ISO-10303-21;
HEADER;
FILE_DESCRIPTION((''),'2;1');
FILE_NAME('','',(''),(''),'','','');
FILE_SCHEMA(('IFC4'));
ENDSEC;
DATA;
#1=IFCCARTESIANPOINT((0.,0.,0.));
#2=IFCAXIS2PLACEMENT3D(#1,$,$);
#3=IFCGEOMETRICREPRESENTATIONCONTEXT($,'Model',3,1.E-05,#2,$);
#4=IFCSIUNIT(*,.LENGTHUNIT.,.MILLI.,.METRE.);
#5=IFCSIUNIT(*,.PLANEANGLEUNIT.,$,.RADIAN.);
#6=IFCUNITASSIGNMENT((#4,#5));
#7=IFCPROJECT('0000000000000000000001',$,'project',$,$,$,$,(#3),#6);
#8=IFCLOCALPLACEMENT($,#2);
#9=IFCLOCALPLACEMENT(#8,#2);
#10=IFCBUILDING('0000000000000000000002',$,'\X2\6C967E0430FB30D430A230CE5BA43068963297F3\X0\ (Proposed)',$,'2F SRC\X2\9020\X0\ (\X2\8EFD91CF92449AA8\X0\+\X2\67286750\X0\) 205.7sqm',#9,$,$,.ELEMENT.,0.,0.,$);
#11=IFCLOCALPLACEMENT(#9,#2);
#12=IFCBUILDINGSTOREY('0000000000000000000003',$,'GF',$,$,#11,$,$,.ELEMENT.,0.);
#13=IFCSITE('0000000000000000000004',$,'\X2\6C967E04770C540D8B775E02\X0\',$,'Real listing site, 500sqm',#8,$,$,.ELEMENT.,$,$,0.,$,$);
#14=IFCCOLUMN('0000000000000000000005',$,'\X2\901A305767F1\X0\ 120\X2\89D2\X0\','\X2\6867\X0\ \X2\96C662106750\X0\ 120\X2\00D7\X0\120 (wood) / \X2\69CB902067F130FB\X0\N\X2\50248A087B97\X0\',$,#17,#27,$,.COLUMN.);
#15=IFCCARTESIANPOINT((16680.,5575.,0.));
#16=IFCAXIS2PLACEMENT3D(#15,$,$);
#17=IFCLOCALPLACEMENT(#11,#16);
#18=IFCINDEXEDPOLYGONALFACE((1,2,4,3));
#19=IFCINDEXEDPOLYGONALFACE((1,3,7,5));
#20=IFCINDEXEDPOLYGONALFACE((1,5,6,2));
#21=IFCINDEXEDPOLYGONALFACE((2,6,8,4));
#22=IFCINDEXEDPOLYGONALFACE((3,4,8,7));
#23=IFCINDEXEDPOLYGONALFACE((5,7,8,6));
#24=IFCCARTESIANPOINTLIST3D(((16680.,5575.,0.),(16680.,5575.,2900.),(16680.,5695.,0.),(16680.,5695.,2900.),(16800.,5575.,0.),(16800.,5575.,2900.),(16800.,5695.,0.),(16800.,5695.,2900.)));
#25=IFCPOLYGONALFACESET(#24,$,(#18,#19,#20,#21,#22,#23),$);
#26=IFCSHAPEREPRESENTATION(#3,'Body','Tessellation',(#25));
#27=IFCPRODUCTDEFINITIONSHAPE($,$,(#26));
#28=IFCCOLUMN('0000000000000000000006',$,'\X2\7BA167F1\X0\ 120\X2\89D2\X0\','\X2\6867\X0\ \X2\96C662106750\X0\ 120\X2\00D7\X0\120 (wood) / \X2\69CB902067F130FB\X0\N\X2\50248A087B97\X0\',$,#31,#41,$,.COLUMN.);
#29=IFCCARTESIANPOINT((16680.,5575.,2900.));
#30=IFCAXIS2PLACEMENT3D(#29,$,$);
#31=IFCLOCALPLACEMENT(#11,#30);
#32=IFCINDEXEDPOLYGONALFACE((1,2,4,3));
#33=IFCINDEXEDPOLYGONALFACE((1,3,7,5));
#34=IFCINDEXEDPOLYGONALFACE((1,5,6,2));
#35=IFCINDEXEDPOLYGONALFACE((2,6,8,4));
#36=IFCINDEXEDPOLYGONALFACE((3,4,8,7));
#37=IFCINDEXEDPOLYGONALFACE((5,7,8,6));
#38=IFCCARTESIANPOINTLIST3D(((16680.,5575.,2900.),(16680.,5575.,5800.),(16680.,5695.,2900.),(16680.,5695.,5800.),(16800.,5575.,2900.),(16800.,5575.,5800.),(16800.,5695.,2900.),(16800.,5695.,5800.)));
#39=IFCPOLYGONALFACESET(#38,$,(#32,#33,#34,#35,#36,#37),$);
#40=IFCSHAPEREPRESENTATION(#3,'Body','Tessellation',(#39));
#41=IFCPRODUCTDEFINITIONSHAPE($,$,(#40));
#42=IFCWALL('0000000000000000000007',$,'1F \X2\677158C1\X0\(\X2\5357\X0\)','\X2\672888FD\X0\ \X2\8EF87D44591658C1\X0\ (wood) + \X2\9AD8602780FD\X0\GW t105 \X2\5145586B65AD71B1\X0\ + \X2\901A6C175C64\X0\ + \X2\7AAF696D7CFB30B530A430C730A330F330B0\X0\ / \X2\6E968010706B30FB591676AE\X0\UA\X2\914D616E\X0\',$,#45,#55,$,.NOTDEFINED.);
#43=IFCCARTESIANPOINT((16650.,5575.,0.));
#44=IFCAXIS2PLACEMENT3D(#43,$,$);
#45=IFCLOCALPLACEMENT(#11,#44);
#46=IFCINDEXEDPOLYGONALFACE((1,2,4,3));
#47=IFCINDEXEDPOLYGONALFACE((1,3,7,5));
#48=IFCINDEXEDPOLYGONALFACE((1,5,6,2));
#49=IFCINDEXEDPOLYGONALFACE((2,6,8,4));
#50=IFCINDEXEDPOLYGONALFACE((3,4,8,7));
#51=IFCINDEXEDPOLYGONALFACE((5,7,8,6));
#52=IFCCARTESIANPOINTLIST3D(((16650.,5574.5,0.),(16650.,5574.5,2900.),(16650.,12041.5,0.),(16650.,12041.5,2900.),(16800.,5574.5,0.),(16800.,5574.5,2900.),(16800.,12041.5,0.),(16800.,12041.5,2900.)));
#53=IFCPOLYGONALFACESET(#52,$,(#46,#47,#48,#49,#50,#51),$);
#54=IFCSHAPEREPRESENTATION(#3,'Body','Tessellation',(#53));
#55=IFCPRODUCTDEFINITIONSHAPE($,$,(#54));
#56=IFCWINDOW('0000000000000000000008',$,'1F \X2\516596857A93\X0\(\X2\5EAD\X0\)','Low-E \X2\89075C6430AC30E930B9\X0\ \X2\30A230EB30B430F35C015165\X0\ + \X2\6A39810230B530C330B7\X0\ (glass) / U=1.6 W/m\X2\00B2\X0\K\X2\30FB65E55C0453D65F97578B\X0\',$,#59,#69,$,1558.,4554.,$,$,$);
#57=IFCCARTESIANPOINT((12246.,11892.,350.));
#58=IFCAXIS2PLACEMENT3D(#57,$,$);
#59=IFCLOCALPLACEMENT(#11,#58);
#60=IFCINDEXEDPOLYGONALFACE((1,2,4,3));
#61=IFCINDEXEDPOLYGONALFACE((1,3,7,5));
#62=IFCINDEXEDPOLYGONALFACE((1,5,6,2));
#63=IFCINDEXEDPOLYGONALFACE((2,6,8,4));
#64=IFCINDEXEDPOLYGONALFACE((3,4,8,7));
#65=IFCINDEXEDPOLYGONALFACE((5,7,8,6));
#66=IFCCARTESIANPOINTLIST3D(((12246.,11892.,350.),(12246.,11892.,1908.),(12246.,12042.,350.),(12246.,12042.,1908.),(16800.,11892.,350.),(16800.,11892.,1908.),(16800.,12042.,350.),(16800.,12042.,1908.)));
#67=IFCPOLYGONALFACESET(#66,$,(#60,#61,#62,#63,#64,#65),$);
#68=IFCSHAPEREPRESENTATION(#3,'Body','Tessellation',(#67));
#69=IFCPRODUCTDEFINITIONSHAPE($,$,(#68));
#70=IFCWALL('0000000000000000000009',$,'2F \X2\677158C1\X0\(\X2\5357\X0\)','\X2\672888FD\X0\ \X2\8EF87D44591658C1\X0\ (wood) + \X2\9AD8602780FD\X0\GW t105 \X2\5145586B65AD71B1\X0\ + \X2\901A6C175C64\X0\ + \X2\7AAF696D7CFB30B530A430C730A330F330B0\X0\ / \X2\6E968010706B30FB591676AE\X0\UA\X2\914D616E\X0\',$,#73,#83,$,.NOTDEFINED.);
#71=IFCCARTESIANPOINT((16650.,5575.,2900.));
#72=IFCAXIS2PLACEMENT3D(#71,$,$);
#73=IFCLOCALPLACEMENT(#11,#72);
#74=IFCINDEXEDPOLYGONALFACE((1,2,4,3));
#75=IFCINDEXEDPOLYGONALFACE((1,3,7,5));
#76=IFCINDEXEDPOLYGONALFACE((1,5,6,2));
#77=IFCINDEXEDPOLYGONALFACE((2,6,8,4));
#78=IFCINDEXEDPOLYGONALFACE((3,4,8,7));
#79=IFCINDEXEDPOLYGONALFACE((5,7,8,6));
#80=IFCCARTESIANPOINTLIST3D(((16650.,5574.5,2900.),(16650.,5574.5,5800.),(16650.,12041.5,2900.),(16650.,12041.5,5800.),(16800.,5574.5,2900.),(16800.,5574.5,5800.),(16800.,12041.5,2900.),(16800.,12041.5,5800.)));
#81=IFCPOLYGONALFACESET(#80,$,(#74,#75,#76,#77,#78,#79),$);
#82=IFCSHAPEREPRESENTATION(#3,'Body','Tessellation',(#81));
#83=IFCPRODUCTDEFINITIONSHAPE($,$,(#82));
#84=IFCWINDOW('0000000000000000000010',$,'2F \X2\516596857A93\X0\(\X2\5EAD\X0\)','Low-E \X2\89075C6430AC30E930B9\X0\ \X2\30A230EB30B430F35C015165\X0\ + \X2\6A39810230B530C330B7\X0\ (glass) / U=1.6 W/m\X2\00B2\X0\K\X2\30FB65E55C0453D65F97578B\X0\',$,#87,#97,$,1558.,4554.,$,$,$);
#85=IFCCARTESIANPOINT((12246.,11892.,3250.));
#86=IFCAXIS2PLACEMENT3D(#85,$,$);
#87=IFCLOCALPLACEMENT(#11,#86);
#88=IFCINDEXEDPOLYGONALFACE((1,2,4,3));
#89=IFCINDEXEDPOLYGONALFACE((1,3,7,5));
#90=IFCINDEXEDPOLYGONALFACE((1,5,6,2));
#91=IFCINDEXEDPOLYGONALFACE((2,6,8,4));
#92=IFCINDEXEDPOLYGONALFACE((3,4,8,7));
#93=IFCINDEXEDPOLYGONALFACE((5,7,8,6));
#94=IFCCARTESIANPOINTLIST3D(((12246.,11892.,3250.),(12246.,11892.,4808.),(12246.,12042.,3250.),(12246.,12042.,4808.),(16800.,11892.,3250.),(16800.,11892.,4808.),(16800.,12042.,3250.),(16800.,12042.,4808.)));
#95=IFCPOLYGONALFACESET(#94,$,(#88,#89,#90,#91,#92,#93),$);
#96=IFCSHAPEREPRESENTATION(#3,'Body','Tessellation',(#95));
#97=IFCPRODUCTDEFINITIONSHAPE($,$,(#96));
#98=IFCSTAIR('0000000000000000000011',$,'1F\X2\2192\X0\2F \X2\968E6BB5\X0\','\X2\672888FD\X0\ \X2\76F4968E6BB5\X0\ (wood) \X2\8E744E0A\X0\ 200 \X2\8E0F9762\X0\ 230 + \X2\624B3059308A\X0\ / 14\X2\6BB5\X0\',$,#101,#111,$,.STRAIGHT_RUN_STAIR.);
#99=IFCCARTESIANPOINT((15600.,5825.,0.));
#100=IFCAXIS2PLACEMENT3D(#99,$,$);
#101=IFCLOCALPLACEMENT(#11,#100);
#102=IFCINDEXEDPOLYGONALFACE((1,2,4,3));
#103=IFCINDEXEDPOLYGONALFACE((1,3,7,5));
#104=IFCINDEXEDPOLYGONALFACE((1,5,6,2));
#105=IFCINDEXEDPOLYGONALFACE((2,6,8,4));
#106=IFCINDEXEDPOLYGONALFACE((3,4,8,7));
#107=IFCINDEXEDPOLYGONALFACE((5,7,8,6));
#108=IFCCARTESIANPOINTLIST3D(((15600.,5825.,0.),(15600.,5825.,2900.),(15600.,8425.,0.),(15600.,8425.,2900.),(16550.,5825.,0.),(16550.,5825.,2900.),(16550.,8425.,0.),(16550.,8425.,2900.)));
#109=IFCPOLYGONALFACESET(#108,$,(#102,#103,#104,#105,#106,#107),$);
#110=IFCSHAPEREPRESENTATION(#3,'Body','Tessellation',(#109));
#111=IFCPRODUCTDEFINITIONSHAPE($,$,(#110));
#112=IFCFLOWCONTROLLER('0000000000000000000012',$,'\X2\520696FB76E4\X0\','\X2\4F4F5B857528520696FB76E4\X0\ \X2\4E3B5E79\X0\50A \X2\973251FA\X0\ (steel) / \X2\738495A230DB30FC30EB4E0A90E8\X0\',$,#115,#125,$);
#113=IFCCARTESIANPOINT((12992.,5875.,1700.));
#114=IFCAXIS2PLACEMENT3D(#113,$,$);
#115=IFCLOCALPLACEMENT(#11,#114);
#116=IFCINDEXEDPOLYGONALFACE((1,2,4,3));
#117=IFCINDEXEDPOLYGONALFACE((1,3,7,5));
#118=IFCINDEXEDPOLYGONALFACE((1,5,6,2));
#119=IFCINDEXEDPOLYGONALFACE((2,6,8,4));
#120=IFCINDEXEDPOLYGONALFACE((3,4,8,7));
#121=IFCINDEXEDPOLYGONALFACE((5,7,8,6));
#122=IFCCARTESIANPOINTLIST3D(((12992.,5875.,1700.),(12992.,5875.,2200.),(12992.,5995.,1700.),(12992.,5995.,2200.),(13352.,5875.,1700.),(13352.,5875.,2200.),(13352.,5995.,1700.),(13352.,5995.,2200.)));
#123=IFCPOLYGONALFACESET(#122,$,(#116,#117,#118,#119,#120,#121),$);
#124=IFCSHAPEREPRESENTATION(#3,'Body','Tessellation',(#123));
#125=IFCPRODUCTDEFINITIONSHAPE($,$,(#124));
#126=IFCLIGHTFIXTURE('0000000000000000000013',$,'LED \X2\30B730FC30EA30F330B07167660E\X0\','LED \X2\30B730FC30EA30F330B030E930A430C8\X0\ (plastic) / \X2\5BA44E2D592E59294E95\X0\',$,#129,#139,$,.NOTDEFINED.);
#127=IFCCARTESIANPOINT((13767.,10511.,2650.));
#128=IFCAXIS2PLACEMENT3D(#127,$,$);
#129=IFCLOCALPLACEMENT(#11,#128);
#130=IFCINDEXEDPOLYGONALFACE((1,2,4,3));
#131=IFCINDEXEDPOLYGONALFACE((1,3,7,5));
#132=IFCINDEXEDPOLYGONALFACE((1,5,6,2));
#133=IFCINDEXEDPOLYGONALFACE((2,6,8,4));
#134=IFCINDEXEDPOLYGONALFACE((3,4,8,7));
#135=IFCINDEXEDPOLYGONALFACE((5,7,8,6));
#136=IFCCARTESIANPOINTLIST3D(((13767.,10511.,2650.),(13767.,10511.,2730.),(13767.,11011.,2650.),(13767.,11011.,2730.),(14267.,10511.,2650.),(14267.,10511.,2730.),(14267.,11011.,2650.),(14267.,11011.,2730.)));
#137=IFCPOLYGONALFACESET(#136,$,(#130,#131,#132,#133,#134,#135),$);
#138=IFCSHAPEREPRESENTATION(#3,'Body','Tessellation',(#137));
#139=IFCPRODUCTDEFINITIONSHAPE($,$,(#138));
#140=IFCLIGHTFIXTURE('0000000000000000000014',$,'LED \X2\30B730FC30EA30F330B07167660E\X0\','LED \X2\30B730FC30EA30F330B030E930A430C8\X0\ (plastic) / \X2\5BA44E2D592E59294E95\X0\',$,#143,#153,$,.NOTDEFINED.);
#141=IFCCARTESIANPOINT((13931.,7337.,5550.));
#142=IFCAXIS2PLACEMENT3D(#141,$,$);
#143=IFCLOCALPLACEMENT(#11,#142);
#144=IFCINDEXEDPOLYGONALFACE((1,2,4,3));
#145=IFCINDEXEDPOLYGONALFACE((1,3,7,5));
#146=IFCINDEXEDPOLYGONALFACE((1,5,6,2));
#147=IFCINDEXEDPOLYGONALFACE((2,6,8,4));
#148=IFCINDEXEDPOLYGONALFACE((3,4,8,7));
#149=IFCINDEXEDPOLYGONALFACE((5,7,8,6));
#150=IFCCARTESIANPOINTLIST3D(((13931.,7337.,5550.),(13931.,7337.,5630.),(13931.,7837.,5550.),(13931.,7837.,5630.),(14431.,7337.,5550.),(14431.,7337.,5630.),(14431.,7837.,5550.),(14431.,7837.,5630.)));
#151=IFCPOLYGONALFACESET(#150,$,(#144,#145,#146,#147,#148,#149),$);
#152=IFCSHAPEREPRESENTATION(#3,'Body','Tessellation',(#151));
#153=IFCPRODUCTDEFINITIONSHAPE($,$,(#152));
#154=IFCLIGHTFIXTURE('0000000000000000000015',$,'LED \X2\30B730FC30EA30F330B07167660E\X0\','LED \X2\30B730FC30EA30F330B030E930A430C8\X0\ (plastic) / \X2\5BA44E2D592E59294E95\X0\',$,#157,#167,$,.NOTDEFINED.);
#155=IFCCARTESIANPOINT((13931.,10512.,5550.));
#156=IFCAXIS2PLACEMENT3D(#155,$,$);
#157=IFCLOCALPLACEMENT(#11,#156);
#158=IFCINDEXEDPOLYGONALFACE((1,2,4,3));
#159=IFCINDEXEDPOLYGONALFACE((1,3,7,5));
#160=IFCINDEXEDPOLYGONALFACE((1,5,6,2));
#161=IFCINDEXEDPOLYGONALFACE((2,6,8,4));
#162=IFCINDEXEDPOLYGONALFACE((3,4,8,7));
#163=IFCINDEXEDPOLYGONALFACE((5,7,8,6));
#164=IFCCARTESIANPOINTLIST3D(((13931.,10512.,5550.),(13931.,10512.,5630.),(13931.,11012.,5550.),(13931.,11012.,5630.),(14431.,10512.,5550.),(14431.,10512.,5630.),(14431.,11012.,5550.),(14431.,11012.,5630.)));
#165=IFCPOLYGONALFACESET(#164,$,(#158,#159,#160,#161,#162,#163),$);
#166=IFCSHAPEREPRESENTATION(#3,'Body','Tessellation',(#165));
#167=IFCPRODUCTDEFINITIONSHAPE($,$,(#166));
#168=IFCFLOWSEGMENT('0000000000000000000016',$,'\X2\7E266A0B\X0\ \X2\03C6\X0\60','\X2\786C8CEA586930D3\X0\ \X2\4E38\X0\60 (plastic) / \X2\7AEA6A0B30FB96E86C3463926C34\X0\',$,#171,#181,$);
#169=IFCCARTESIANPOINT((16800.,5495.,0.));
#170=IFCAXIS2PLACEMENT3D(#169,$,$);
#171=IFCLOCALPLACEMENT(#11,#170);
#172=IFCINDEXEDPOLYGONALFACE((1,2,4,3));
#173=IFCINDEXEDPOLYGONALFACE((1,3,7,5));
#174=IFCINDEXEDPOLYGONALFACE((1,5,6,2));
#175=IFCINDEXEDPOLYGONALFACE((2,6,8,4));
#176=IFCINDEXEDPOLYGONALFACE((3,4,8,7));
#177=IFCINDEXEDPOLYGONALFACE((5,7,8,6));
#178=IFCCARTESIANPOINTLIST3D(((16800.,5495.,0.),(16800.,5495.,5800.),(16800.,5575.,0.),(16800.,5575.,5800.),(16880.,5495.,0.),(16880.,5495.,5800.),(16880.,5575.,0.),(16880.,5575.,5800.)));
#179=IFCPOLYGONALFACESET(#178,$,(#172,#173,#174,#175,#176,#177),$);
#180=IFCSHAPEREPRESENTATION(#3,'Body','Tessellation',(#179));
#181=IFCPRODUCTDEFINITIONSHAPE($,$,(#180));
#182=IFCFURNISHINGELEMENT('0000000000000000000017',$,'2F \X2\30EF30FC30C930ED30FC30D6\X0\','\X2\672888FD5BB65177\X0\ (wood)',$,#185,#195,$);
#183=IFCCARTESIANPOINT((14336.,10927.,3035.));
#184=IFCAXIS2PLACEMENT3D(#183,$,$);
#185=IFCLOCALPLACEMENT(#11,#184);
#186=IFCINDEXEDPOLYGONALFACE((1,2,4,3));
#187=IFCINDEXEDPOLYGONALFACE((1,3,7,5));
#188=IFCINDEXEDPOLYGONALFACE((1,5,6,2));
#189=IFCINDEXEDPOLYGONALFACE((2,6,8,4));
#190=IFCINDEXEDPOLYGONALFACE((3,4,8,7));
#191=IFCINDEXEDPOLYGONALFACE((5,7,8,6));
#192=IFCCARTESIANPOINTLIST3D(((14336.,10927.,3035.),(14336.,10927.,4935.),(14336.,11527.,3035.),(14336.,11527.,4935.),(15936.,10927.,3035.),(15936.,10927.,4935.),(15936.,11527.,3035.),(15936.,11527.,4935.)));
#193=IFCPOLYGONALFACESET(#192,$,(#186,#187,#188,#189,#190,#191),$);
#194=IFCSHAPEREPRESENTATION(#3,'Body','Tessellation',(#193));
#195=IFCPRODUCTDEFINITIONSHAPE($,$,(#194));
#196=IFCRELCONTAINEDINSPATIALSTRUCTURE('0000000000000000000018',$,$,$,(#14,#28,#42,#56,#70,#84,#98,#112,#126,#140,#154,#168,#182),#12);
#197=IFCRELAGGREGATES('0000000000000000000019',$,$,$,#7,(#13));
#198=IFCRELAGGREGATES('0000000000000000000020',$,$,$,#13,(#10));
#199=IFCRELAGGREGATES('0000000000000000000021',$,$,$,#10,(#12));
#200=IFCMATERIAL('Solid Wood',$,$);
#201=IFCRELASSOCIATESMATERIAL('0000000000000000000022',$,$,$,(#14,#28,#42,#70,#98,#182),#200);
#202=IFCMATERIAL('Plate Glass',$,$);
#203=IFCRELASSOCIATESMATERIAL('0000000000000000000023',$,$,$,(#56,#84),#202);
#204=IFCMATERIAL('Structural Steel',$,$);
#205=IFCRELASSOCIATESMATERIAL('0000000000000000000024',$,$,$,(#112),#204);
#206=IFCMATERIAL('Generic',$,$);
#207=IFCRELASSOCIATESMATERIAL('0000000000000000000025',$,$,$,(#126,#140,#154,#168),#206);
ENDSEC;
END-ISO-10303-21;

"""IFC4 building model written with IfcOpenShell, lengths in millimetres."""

from ifc_helpers import new_model, si_unit, frame, frame_2d, origin, place, context, project, spatial, rectangle, extrude, material, element, fill, save


model = new_model("IFC4")

# Units and contexts
model_context = context("Model", 3, precision=1e-05, world=origin())
ifc_project = project(units=[si_unit("LENGTHUNIT", "METRE", prefix="MILLI"), si_unit("PLANEANGLEUNIT", "RADIAN")], contexts=[model_context])

# Site, building, storey
site_placement = place(None, origin())
site = spatial("IfcSite", under=ifc_project, at=site_placement, Name="沖縄県名護市", ObjectType="Real listing site, 500sqm", CompositionType="ELEMENT", RefElevation=0.0)
building_placement = place(site_placement, origin())
building = spatial("IfcBuilding", under=site, at=building_placement, Name="沖縄・ピアノ室と防音 (Proposed)", ObjectType="2F SRC造 (軽量鉄骨+木材) 205.7sqm", CompositionType="ELEMENT", ElevationOfRefHeight=0.0, ElevationOfTerrain=0.0)
storey_placement = place(building_placement, origin())
storey = spatial("IfcBuildingStorey", under=building, at=storey_placement, Name="GF", CompositionType="ELEMENT", Elevation=0.0)

# Columns
ifc_material_1 = material(Name="Solid Wood")
column_1_placement = place(storey_placement, frame((16680.0, 5575.0, 0.0)))
element("IfcColumn", 1, at=column_1_placement, inside=storey, material=ifc_material_1, Name="通し柱 120角", Description="桧 集成材 120×120 (wood) / 構造柱・N値計算", PredefinedType="COLUMN", context=model_context, shape_type="SweptSolid", body=[
    extrude(rectangle(XDim=120.0, YDim=120.0, at=frame_2d((60.0, 60.0))), frame((16680.0, 5575.0, 0.0)), (0.0, 0.0, 1.0), 2900.0),
])
column_2_placement = place(storey_placement, frame((16680.0, 5575.0, 2900.0)))
element("IfcColumn", 2, at=column_2_placement, inside=storey, material=ifc_material_1, Name="管柱 120角", Description="桧 集成材 120×120 (wood) / 構造柱・N値計算", PredefinedType="COLUMN", context=model_context, shape_type="SweptSolid", body=[
    extrude(rectangle(XDim=120.0, YDim=120.0, at=frame_2d((60.0, 60.0))), frame((16680.0, 5575.0, 2900.0)), (0.0, 0.0, 1.0), 2900.0),
])

# Wall, opening, window
wall_1_placement = place(storey_placement, frame((16650.0, 5575.0, 0.0)))
wall_1 = element("IfcWall", 3, at=wall_1_placement, inside=storey, material=ifc_material_1, Name="1F 東壁(南)", Description="木製 軸組外壁 (wood) + 高性能GW t105 充填断熱 + 通気層 + 窯業系サイディング / 準耐火・外皮UA配慮", PredefinedType="NOTDEFINED", context=model_context, shape_type="SweptSolid", body=[
    extrude(rectangle(XDim=150.0, YDim=6467.0, at=frame_2d((75.0, 3233.0))), frame((16650.0, 5575.0, 0.0)), (0.0, 0.0, 1.0), 2900.0),
])
opening_1_placement = place(storey_placement, frame((12246.0, 11892.0, 350.0)))
opening_1 = element("IfcOpeningElement", 4, at=opening_1_placement, cuts=wall_1, PredefinedType="NOTDEFINED", context=model_context, shape_type="SweptSolid", body=[
    extrude(rectangle(XDim=4554.0, YDim=150.0, at=frame_2d((2277.0, 75.0))), frame((12246.0, 11892.0, 350.0)), (0.0, 0.0, 1.0), 1558.0),
])
ifc_material_2 = material(Name="Plate Glass")
window_1_placement = place(storey_placement, frame((12246.0, 11892.0, 350.0)))
window_1 = element("IfcWindow", 5, at=window_1_placement, inside=storey, material=ifc_material_2, Name="1F 入隅窓(庭)", Description="Low-E 複層ガラス アルゴン封入 + 樹脂サッシ (glass) / U=1.6 W/m²K・日射取得型", OverallHeight=1558.0, OverallWidth=4554.0, context=model_context, shape_type="SweptSolid", body=[
    extrude(rectangle(XDim=4554.0, YDim=150.0, at=frame_2d((2277.0, 75.0))), frame((12246.0, 11892.0, 350.0)), (0.0, 0.0, 1.0), 1558.0),
])
fill(opening_1, window_1)

# Wall, opening, window
wall_2_placement = place(storey_placement, frame((16650.0, 5575.0, 2900.0)))
wall_2 = element("IfcWall", 6, at=wall_2_placement, inside=storey, material=ifc_material_1, Name="2F 東壁(南)", Description="木製 軸組外壁 (wood) + 高性能GW t105 充填断熱 + 通気層 + 窯業系サイディング / 準耐火・外皮UA配慮", PredefinedType="NOTDEFINED", context=model_context, shape_type="SweptSolid", body=[
    extrude(rectangle(XDim=150.0, YDim=6467.0, at=frame_2d((75.0, 3233.0))), frame((16650.0, 5575.0, 2900.0)), (0.0, 0.0, 1.0), 2900.0),
])
opening_2_placement = place(storey_placement, frame((12246.0, 11892.0, 3250.0)))
opening_2 = element("IfcOpeningElement", 7, at=opening_2_placement, cuts=wall_2, PredefinedType="NOTDEFINED", context=model_context, shape_type="SweptSolid", body=[
    extrude(rectangle(XDim=4554.0, YDim=150.0, at=frame_2d((2277.0, 75.0))), frame((12246.0, 11892.0, 3250.0)), (0.0, 0.0, 1.0), 1558.0),
])
window_2_placement = place(storey_placement, frame((12246.0, 11892.0, 3250.0)))
window_2 = element("IfcWindow", 8, at=window_2_placement, inside=storey, material=ifc_material_2, Name="2F 入隅窓(庭)", Description="Low-E 複層ガラス アルゴン封入 + 樹脂サッシ (glass) / U=1.6 W/m²K・日射取得型", OverallHeight=1558.0, OverallWidth=4554.0, context=model_context, shape_type="SweptSolid", body=[
    extrude(rectangle(XDim=4554.0, YDim=150.0, at=frame_2d((2277.0, 75.0))), frame((12246.0, 11892.0, 3250.0)), (0.0, 0.0, 1.0), 1558.0),
])
fill(opening_2, window_2)

# Stair
stair_placement = place(storey_placement, frame((15600.0, 5825.0, 0.0)))
element("IfcStair", 9, at=stair_placement, inside=storey, material=ifc_material_1, Name="1F→2F 階段", Description="木製 直階段 (wood) 蹴上 200 踏面 230 + 手すり / 14段", PredefinedType="STRAIGHT_RUN_STAIR", context=model_context, shape_type="SweptSolid", body=[
    extrude(rectangle(XDim=950.0, YDim=2600.0, at=frame_2d((475.0, 1300.0))), frame((15600.0, 5825.0, 0.0)), (0.0, 0.0, 1.0), 2900.0),
])

# Flow controller
ifc_material_3 = material(Name="Structural Steel")
flow_controller_placement = place(storey_placement, frame((12992.0, 5875.0, 1700.0)))
element("IfcFlowController", 10, at=flow_controller_placement, inside=storey, material=ifc_material_3, Name="分電盤", Description="住宅用分電盤 主幹50A 露出 (steel) / 玄関ホール上部", context=model_context, shape_type="SweptSolid", body=[
    extrude(rectangle(XDim=360.0, YDim=120.0, at=frame_2d((180.0, 60.0))), frame((12992.0, 5875.0, 1700.0)), (0.0, 0.0, 1.0), 500.0),
])

# Light fixtures
ifc_material_4 = material(Name="Generic")
light_fixture_1_placement = place(storey_placement, frame((13767.0, 10511.0, 2650.0)))
element("IfcLightFixture", 11, at=light_fixture_1_placement, inside=storey, material=ifc_material_4, Name="LED シーリング照明", Description="LED シーリングライト (plastic) / 室中央天井", PredefinedType="NOTDEFINED", context=model_context, shape_type="SweptSolid", body=[
    extrude(rectangle(XDim=500.0, YDim=500.0, at=frame_2d((250.0, 250.0))), frame((13767.0, 10511.0, 2650.0)), (0.0, 0.0, 1.0), 80.0),
])
light_fixture_2_placement = place(storey_placement, frame((13931.0, 7337.0, 5550.0)))
element("IfcLightFixture", 12, at=light_fixture_2_placement, inside=storey, material=ifc_material_4, Name="LED シーリング照明", Description="LED シーリングライト (plastic) / 室中央天井", PredefinedType="NOTDEFINED", context=model_context, shape_type="SweptSolid", body=[
    extrude(rectangle(XDim=500.0, YDim=500.0, at=frame_2d((250.0, 250.0))), frame((13931.0, 7337.0, 5550.0)), (0.0, 0.0, 1.0), 80.0),
])
light_fixture_3_placement = place(storey_placement, frame((13931.0, 10512.0, 5550.0)))
element("IfcLightFixture", 13, at=light_fixture_3_placement, inside=storey, material=ifc_material_4, Name="LED シーリング照明", Description="LED シーリングライト (plastic) / 室中央天井", PredefinedType="NOTDEFINED", context=model_context, shape_type="SweptSolid", body=[
    extrude(rectangle(XDim=500.0, YDim=500.0, at=frame_2d((250.0, 250.0))), frame((13931.0, 10512.0, 5550.0)), (0.0, 0.0, 1.0), 80.0),
])

# Flow segment
flow_segment_placement = place(storey_placement, frame((16800.0, 5495.0, 0.0)))
element("IfcFlowSegment", 14, at=flow_segment_placement, inside=storey, material=ifc_material_4, Name="縦樋 φ60", Description="硬質塩ビ 丸60 (plastic) / 竪樋・雨水排水", context=model_context, shape_type="SweptSolid", body=[
    extrude(rectangle(XDim=80.0, YDim=80.0, at=frame_2d((40.0, 40.0))), frame((16800.0, 5495.0, 0.0)), (0.0, 0.0, 1.0), 5800.0),
])

# Furnishing element
furnishing_1_placement = place(storey_placement, frame((14336.0, 10927.0, 3035.0)))
element("IfcFurnishingElement", 15, at=furnishing_1_placement, inside=storey, material=ifc_material_1, Name="2F ワードローブ", Description="木製家具 (wood)", context=model_context, shape_type="SweptSolid", body=[
    extrude(rectangle(XDim=1600.0, YDim=600.0, at=frame_2d((800.0, 300.0))), frame((14336.0, 10927.0, 3035.0)), (0.0, 0.0, 1.0), 1900.0),
])

save(model, "model.ifc")
